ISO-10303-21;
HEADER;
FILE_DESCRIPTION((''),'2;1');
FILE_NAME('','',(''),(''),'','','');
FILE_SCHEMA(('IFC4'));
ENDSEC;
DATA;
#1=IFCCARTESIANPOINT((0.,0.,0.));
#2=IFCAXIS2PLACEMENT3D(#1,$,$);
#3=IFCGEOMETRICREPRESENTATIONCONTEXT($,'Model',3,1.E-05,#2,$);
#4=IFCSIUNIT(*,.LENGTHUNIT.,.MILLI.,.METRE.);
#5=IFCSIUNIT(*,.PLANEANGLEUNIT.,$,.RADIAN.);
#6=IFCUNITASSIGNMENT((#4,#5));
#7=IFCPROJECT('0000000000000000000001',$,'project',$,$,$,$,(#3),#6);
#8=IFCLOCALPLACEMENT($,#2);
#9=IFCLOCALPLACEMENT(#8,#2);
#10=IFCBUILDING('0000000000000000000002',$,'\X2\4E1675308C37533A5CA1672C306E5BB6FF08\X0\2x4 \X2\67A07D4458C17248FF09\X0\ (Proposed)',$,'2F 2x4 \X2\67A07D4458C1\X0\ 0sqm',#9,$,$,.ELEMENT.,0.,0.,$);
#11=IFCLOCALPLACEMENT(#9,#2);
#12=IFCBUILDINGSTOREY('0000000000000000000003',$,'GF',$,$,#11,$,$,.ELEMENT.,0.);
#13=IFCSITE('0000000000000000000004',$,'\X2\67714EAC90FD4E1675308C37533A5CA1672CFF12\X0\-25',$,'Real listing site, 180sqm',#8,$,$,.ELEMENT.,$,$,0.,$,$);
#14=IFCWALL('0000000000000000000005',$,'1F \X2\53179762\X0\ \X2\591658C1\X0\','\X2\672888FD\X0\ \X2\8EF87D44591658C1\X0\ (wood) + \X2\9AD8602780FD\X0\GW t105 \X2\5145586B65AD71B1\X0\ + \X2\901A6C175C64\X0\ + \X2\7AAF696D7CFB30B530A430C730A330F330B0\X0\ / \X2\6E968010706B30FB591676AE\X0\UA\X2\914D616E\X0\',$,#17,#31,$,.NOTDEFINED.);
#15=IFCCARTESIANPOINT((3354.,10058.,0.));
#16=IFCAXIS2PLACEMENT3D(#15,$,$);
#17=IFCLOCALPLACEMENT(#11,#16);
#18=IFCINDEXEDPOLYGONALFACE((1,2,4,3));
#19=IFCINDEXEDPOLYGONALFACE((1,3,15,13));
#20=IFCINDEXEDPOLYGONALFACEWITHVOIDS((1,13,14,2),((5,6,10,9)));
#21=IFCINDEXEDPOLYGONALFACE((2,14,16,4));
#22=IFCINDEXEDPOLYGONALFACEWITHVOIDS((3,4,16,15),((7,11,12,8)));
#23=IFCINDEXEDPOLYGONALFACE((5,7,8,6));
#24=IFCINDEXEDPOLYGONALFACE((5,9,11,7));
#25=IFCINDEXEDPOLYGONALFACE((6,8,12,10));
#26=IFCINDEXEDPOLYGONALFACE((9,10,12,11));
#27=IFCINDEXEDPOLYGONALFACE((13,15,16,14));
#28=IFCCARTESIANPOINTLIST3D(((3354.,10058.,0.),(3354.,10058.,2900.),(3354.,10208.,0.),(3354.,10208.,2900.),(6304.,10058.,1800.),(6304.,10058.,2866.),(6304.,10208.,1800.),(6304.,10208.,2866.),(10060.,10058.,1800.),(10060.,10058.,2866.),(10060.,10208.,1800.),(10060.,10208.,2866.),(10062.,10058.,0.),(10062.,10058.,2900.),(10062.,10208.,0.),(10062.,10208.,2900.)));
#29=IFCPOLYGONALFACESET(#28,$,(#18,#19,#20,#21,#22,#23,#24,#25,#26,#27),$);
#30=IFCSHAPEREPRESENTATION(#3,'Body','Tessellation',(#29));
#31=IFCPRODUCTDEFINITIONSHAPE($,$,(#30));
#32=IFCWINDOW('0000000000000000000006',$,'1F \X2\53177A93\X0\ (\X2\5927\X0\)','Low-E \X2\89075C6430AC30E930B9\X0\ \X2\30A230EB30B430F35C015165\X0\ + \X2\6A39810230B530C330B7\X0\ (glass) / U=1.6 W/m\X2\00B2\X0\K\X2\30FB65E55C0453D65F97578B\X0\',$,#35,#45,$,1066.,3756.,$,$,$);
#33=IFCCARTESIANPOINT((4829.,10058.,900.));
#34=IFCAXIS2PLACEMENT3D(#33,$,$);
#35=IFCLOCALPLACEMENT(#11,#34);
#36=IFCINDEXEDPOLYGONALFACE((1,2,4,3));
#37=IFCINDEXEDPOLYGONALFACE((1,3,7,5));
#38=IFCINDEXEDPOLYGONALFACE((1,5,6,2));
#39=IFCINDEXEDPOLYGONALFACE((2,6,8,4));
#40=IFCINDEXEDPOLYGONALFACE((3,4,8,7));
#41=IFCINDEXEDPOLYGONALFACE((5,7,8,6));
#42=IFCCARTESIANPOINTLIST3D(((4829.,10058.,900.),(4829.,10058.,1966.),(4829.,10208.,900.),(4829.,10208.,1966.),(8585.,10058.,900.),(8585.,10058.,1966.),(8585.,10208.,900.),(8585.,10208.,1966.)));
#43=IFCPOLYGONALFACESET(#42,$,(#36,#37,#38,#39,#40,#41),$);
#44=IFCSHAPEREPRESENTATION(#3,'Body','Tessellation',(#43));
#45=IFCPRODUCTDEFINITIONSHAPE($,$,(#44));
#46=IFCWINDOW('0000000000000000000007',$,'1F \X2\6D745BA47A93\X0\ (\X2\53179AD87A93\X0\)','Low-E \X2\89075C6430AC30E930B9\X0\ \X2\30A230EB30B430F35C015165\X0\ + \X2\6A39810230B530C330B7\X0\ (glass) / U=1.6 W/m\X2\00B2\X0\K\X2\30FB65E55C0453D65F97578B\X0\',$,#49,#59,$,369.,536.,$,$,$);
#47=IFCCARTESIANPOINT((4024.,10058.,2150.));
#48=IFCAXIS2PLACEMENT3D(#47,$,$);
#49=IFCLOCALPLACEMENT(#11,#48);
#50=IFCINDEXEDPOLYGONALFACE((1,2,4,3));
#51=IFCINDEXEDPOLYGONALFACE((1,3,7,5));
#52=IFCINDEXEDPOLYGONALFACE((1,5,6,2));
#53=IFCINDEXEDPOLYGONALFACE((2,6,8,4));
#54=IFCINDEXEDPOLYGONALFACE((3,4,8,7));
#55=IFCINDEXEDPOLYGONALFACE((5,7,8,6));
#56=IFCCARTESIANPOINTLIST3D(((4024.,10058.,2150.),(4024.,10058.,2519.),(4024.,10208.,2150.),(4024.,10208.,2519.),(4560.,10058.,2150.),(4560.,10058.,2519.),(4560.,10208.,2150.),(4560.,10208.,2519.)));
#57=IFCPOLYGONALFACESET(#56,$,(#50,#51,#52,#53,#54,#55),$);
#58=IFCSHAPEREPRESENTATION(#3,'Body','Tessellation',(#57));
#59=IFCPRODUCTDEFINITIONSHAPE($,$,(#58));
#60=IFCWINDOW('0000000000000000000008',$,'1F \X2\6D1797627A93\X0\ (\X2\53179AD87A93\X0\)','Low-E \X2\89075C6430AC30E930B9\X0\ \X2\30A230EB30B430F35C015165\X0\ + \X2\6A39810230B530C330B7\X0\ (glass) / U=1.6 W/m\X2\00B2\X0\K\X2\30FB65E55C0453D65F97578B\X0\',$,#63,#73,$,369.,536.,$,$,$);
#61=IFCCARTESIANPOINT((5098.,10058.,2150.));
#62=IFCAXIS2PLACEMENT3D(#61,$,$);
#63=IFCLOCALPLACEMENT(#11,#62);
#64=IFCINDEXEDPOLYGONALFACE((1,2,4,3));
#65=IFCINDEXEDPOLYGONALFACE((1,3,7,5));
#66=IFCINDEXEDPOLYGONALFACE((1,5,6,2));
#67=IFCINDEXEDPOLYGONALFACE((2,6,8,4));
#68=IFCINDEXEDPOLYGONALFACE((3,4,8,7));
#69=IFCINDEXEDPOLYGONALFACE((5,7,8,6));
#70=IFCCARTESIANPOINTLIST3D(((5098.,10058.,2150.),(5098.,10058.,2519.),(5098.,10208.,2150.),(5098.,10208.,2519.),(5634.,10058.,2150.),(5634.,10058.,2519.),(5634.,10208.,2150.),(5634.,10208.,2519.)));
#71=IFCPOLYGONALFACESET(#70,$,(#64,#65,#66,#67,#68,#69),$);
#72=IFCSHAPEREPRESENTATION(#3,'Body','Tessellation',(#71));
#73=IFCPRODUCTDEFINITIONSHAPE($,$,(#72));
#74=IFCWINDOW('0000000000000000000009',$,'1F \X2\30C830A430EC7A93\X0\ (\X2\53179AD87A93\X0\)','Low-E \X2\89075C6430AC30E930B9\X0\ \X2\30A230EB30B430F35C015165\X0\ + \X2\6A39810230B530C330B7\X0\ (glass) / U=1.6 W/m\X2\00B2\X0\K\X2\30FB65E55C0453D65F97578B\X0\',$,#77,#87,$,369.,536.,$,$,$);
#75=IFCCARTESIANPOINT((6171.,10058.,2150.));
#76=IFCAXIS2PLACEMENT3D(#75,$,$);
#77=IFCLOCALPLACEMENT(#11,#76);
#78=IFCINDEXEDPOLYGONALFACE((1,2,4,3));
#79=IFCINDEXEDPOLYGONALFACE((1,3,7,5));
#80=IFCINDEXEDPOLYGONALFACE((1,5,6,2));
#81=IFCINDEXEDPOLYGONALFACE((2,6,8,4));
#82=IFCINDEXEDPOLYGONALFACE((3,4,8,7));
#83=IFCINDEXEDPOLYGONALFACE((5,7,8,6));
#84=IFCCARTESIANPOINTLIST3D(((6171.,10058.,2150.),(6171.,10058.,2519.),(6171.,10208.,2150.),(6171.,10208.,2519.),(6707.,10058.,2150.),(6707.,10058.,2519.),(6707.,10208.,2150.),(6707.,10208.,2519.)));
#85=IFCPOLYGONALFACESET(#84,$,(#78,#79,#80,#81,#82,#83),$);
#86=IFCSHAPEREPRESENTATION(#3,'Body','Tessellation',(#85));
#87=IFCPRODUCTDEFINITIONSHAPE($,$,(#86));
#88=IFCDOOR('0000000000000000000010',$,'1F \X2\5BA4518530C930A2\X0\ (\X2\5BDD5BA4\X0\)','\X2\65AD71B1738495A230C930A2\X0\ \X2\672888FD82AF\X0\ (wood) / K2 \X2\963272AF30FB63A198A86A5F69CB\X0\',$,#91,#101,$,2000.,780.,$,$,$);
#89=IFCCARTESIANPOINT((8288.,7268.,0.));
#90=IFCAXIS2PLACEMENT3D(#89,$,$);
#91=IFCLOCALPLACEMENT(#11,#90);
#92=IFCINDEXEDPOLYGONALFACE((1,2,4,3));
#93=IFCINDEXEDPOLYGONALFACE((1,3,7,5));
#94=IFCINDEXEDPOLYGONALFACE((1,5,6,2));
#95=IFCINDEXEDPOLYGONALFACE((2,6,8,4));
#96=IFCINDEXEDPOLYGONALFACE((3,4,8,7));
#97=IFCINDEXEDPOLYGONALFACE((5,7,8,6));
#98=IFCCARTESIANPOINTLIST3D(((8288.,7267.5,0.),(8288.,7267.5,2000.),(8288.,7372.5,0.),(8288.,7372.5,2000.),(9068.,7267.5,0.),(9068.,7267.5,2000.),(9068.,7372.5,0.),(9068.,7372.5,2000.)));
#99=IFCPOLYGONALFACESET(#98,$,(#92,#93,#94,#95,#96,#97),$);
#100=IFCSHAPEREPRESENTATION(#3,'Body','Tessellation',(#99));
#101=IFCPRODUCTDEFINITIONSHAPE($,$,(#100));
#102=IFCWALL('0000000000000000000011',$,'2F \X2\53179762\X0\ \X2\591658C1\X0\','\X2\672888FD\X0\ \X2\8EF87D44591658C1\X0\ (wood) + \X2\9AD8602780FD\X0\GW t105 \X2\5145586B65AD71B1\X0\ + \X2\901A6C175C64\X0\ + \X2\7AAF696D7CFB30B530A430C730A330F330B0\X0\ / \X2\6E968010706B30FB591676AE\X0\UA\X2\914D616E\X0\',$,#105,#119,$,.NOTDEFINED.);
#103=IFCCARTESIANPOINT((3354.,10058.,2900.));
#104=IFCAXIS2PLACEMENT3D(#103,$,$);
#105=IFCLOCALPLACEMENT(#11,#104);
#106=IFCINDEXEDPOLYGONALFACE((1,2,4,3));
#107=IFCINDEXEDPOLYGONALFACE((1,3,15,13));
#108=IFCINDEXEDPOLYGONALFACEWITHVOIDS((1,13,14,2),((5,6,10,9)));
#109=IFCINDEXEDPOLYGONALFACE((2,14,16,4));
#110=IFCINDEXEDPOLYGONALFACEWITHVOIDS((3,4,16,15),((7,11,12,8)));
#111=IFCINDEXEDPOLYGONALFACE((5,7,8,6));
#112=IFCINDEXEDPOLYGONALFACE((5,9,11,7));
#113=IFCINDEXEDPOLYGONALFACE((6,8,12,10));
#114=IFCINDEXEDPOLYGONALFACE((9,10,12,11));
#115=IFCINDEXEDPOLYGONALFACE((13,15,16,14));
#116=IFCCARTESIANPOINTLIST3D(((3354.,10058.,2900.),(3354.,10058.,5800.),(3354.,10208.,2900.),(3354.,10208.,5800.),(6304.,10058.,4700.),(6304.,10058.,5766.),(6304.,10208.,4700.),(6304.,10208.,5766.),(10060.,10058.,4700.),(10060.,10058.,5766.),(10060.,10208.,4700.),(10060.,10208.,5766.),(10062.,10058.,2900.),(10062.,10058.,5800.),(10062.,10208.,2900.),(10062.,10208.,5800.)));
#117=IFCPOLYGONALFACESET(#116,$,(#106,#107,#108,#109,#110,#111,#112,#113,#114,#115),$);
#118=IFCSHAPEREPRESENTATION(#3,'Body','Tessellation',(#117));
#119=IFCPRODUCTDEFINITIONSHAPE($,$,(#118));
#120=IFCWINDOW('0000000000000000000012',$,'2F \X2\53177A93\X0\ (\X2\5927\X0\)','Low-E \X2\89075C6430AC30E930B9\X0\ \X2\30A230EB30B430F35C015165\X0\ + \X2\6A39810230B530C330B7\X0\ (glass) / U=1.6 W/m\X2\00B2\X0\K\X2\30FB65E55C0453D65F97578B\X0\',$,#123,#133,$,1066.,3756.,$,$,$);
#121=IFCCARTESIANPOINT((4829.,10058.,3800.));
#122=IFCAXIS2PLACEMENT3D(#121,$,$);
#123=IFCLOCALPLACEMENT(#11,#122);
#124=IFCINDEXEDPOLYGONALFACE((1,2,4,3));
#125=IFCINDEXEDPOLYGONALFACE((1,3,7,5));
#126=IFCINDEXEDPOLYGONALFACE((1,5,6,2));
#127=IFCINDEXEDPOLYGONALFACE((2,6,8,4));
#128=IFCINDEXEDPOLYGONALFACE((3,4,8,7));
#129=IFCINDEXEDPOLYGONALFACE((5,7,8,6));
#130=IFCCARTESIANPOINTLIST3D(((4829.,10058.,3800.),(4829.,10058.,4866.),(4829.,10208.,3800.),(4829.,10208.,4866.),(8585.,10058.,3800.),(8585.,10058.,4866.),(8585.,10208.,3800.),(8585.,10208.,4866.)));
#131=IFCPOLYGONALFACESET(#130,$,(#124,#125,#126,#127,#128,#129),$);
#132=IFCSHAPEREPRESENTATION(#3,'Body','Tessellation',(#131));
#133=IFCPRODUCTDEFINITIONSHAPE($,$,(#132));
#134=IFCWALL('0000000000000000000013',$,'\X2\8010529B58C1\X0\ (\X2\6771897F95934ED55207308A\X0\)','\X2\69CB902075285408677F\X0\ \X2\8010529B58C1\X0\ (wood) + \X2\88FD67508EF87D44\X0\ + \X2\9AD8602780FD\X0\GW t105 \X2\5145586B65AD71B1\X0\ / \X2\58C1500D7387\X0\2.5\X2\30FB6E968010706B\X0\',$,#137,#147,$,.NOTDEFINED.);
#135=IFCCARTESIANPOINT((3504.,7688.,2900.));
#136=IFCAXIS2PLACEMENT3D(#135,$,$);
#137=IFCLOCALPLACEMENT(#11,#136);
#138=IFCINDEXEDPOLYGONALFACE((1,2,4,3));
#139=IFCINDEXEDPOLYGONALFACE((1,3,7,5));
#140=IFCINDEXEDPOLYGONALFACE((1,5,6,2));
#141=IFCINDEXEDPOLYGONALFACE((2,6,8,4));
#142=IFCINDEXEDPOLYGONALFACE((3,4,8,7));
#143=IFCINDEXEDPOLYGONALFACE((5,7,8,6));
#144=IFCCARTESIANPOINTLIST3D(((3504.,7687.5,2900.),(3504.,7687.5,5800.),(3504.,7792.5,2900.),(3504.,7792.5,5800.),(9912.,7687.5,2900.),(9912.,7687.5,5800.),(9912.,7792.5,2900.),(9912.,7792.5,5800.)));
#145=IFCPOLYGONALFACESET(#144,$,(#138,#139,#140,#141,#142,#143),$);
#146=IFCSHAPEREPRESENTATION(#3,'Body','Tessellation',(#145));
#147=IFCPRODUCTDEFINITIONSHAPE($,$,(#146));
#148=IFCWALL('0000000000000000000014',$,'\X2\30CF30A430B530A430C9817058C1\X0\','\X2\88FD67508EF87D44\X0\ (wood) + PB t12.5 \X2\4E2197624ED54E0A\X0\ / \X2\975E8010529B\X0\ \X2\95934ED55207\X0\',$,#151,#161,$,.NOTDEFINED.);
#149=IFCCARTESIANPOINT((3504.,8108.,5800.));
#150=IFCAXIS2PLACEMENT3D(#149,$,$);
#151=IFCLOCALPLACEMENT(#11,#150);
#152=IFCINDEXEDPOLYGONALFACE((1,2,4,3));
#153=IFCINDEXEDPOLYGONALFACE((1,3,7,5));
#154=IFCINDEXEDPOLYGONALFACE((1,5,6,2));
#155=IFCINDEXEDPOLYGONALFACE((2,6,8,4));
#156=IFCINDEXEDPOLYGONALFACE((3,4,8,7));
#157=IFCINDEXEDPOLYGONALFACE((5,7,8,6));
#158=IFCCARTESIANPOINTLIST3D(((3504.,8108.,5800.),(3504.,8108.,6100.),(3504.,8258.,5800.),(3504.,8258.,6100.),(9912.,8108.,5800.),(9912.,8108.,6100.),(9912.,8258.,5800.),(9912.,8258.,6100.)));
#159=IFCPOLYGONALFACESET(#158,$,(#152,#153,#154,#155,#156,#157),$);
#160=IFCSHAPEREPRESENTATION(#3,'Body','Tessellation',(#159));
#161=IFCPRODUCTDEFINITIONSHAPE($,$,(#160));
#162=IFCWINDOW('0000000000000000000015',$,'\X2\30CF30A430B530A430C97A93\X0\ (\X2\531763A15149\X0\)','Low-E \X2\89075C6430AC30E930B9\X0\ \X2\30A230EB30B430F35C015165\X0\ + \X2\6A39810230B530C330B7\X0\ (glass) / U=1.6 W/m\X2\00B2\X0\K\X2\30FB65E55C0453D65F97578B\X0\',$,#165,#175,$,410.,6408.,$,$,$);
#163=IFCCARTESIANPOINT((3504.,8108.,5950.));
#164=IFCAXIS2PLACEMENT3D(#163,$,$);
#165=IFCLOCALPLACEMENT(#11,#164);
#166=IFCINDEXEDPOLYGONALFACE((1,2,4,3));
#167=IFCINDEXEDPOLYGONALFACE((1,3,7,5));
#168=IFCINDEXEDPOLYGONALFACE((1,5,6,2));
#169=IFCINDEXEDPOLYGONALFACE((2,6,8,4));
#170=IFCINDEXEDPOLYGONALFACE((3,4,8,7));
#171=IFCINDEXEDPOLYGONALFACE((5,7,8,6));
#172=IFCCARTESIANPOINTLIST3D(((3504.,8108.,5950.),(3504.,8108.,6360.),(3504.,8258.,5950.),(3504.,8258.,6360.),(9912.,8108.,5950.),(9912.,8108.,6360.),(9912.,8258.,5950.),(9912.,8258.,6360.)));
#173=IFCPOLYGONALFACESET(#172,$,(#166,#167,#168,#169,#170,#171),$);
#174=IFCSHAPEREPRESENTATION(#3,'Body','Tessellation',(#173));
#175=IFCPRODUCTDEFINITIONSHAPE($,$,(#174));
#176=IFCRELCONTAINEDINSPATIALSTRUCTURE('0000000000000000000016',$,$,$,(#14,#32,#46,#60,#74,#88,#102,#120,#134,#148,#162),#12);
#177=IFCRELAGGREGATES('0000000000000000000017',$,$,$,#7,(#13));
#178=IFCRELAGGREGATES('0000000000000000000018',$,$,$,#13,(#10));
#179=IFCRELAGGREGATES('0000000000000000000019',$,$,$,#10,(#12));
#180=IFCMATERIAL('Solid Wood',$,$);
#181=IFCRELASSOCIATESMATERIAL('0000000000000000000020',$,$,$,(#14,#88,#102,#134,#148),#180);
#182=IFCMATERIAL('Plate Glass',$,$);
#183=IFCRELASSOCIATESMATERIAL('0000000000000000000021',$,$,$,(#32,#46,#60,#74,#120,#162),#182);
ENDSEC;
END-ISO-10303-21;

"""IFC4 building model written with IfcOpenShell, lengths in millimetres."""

from ifc_helpers import new_model, si_unit, frame, frame_2d, origin, place, context, project, spatial, rectangle, extrude, material, element, fill, save


model = new_model("IFC4")

# Units and contexts
model_context = context("Model", 3, precision=1e-05, world=origin())
ifc_project = project(units=[si_unit("LENGTHUNIT", "METRE", prefix="MILLI"), si_unit("PLANEANGLEUNIT", "RADIAN")], contexts=[model_context])

# Site, building, storey
site_placement = place(None, origin())
site = spatial("IfcSite", under=ifc_project, at=site_placement, Name="東京都世田谷区岡本２-25", ObjectType="Real listing site, 180sqm", CompositionType="ELEMENT", RefElevation=0.0)
building_placement = place(site_placement, origin())
building = spatial("IfcBuilding", under=site, at=building_placement, Name="世田谷区岡本の家（2x4 枠組壁版） (Proposed)", ObjectType="2F 2x4 枠組壁 0sqm", CompositionType="ELEMENT", ElevationOfRefHeight=0.0, ElevationOfTerrain=0.0)
storey_placement = place(building_placement, origin())
storey = spatial("IfcBuildingStorey", under=building, at=storey_placement, Name="GF", CompositionType="ELEMENT", Elevation=0.0)

# Wall, openings, windows
ifc_material_1 = material(Name="Solid Wood")
wall_1_placement = place(storey_placement, frame((3354.0, 10058.0, 0.0)))
wall_1 = element("IfcWall", 1, at=wall_1_placement, inside=storey, material=ifc_material_1, Name="1F 北面 外壁", Description="木製 軸組外壁 (wood) + 高性能GW t105 充填断熱 + 通気層 + 窯業系サイディング / 準耐火・外皮UA配慮", PredefinedType="NOTDEFINED", context=model_context, shape_type="SweptSolid", body=[
    extrude(rectangle(XDim=6708.0, YDim=150.0, at=frame_2d((3354.0, 75.0))), frame((3354.0, 10058.0, 0.0)), (0.0, 0.0, 1.0), 2900.0),
])
opening_1_placement = place(storey_placement, frame((4829.0, 10058.0, 900.0)))
opening_1 = element("IfcOpeningElement", 2, at=opening_1_placement, cuts=wall_1, PredefinedType="NOTDEFINED", context=model_context, shape_type="SweptSolid", body=[
    extrude(rectangle(XDim=3756.0, YDim=150.0, at=frame_2d((1878.0, 75.0))), frame((4829.0, 10058.0, 900.0)), (0.0, 0.0, 1.0), 1066.0),
])
opening_2_placement = place(storey_placement, frame((4024.0, 10058.0, 2150.0)))
opening_2 = element("IfcOpeningElement", 3, at=opening_2_placement, cuts=wall_1, PredefinedType="NOTDEFINED", context=model_context, shape_type="SweptSolid", body=[
    extrude(rectangle(XDim=536.0, YDim=150.0, at=frame_2d((268.0, 75.0))), frame((4024.0, 10058.0, 2150.0)), (0.0, 0.0, 1.0), 369.0),
])
opening_3_placement = place(storey_placement, frame((5098.0, 10058.0, 2150.0)))
opening_3 = element("IfcOpeningElement", 4, at=opening_3_placement, cuts=wall_1, PredefinedType="NOTDEFINED", context=model_context, shape_type="SweptSolid", body=[
    extrude(rectangle(XDim=536.0, YDim=150.0, at=frame_2d((268.0, 75.0))), frame((5098.0, 10058.0, 2150.0)), (0.0, 0.0, 1.0), 369.0),
])
opening_4_placement = place(storey_placement, frame((6171.0, 10058.0, 2150.0)))
opening_4 = element("IfcOpeningElement", 5, at=opening_4_placement, cuts=wall_1, PredefinedType="NOTDEFINED", context=model_context, shape_type="SweptSolid", body=[
    extrude(rectangle(XDim=536.0, YDim=150.0, at=frame_2d((268.0, 75.0))), frame((6171.0, 10058.0, 2150.0)), (0.0, 0.0, 1.0), 369.0),
])
ifc_material_2 = material(Name="Plate Glass")
window_1_placement = place(storey_placement, frame((4829.0, 10058.0, 900.0)))
window_1 = element("IfcWindow", 6, at=window_1_placement, inside=storey, material=ifc_material_2, Name="1F 北窓 (大)", Description="Low-E 複層ガラス アルゴン封入 + 樹脂サッシ (glass) / U=1.6 W/m²K・日射取得型", OverallHeight=1066.0, OverallWidth=3756.0, context=model_context, shape_type="SweptSolid", body=[
    extrude(rectangle(XDim=3756.0, YDim=150.0, at=frame_2d((1878.0, 75.0))), frame((4829.0, 10058.0, 900.0)), (0.0, 0.0, 1.0), 1066.0),
])
fill(opening_1, window_1)
window_2_placement = place(storey_placement, frame((4024.0, 10058.0, 2150.0)))
window_2 = element("IfcWindow", 7, at=window_2_placement, inside=storey, material=ifc_material_2, Name="1F 浴室窓 (北高窓)", Description="Low-E 複層ガラス アルゴン封入 + 樹脂サッシ (glass) / U=1.6 W/m²K・日射取得型", OverallHeight=369.0, OverallWidth=536.0, context=model_context, shape_type="SweptSolid", body=[
    extrude(rectangle(XDim=536.0, YDim=150.0, at=frame_2d((268.0, 75.0))), frame((4024.0, 10058.0, 2150.0)), (0.0, 0.0, 1.0), 369.0),
])
fill(opening_2, window_2)
window_3_placement = place(storey_placement, frame((5098.0, 10058.0, 2150.0)))
window_3 = element("IfcWindow", 8, at=window_3_placement, inside=storey, material=ifc_material_2, Name="1F 洗面窓 (北高窓)", Description="Low-E 複層ガラス アルゴン封入 + 樹脂サッシ (glass) / U=1.6 W/m²K・日射取得型", OverallHeight=369.0, OverallWidth=536.0, context=model_context, shape_type="SweptSolid", body=[
    extrude(rectangle(XDim=536.0, YDim=150.0, at=frame_2d((268.0, 75.0))), frame((5098.0, 10058.0, 2150.0)), (0.0, 0.0, 1.0), 369.0),
])
fill(opening_3, window_3)
window_4_placement = place(storey_placement, frame((6171.0, 10058.0, 2150.0)))
window_4 = element("IfcWindow", 9, at=window_4_placement, inside=storey, material=ifc_material_2, Name="1F トイレ窓 (北高窓)", Description="Low-E 複層ガラス アルゴン封入 + 樹脂サッシ (glass) / U=1.6 W/m²K・日射取得型", OverallHeight=369.0, OverallWidth=536.0, context=model_context, shape_type="SweptSolid", body=[
    extrude(rectangle(XDim=536.0, YDim=150.0, at=frame_2d((268.0, 75.0))), frame((6171.0, 10058.0, 2150.0)), (0.0, 0.0, 1.0), 369.0),
])
fill(opening_4, window_4)

# Door
door_1_placement = place(storey_placement, frame((8288.0, 7268.0, 0.0)))
element("IfcDoor", 10, at=door_1_placement, inside=storey, material=ifc_material_1, Name="1F 室内ドア (寝室)", Description="断熱玄関ドア 木製芯 (wood) / K2 防犯・採風機構", OverallHeight=2000.0, OverallWidth=780.0, context=model_context, shape_type="SweptSolid", body=[
    extrude(rectangle(XDim=780.0, YDim=105.0, at=frame_2d((390.0, 52.0))), frame((8288.0, 7268.0, 0.0)), (0.0, 0.0, 1.0), 2000.0),
])

# Wall, opening, window
wall_2_placement = place(storey_placement, frame((3354.0, 10058.0, 2900.0)))
wall_2 = element("IfcWall", 11, at=wall_2_placement, inside=storey, material=ifc_material_1, Name="2F 北面 外壁", Description="木製 軸組外壁 (wood) + 高性能GW t105 充填断熱 + 通気層 + 窯業系サイディング / 準耐火・外皮UA配慮", PredefinedType="NOTDEFINED", context=model_context, shape_type="SweptSolid", body=[
    extrude(rectangle(XDim=6708.0, YDim=150.0, at=frame_2d((3354.0, 75.0))), frame((3354.0, 10058.0, 2900.0)), (0.0, 0.0, 1.0), 2900.0),
])
opening_5_placement = place(storey_placement, frame((4829.0, 10058.0, 3800.0)))
opening_5 = element("IfcOpeningElement", 12, at=opening_5_placement, cuts=wall_2, PredefinedType="NOTDEFINED", context=model_context, shape_type="SweptSolid", body=[
    extrude(rectangle(XDim=3756.0, YDim=150.0, at=frame_2d((1878.0, 75.0))), frame((4829.0, 10058.0, 3800.0)), (0.0, 0.0, 1.0), 1066.0),
])
window_5_placement = place(storey_placement, frame((4829.0, 10058.0, 3800.0)))
window_5 = element("IfcWindow", 13, at=window_5_placement, inside=storey, material=ifc_material_2, Name="2F 北窓 (大)", Description="Low-E 複層ガラス アルゴン封入 + 樹脂サッシ (glass) / U=1.6 W/m²K・日射取得型", OverallHeight=1066.0, OverallWidth=3756.0, context=model_context, shape_type="SweptSolid", body=[
    extrude(rectangle(XDim=3756.0, YDim=150.0, at=frame_2d((1878.0, 75.0))), frame((4829.0, 10058.0, 3800.0)), (0.0, 0.0, 1.0), 1066.0),
])
fill(opening_5, window_5)

# Wall
wall_3_placement = place(storey_placement, frame((3504.0, 7688.0, 2900.0)))
element("IfcWall", 14, at=wall_3_placement, inside=storey, material=ifc_material_1, Name="耐力壁 (東西間仕切り)", Description="構造用合板 耐力壁 (wood) + 製材軸組 + 高性能GW t105 充填断熱 / 壁倍率2.5・準耐火", PredefinedType="NOTDEFINED", context=model_context, shape_type="SweptSolid", body=[
    extrude(rectangle(XDim=6408.0, YDim=105.0, at=frame_2d((3204.0, 52.0))), frame((3504.0, 7688.0, 2900.0)), (0.0, 0.0, 1.0), 2900.0),
])

# Wall, opening, window
wall_4_placement = place(storey_placement, frame((3504.0, 8108.0, 5800.0)))
wall_4 = element("IfcWall", 15, at=wall_4_placement, inside=storey, material=ifc_material_1, Name="ハイサイド腰壁", Description="製材軸組 (wood) + PB t12.5 両面仕上 / 非耐力 間仕切", PredefinedType="NOTDEFINED", context=model_context, shape_type="SweptSolid", body=[
    extrude(rectangle(XDim=6408.0, YDim=150.0, at=frame_2d((3204.0, 75.0))), frame((3504.0, 8108.0, 5800.0)), (0.0, 0.0, 1.0), 700.0),
])
opening_6_placement = place(storey_placement, frame((3504.0, 8108.0, 5950.0)))
opening_6 = element("IfcOpeningElement", 16, at=opening_6_placement, cuts=wall_4, PredefinedType="NOTDEFINED", context=model_context, shape_type="SweptSolid", body=[
    extrude(rectangle(XDim=6408.0, YDim=150.0, at=frame_2d((3204.0, 75.0))), frame((3504.0, 8108.0, 5950.0)), (0.0, 0.0, 1.0), 410.0),
])
window_6_placement = place(storey_placement, frame((3504.0, 8108.0, 5950.0)))
window_6 = element("IfcWindow", 17, at=window_6_placement, inside=storey, material=ifc_material_2, Name="ハイサイド窓 (北採光)", Description="Low-E 複層ガラス アルゴン封入 + 樹脂サッシ (glass) / U=1.6 W/m²K・日射取得型", OverallHeight=410.0, OverallWidth=6408.0, context=model_context, shape_type="SweptSolid", body=[
    extrude(rectangle(XDim=6408.0, YDim=150.0, at=frame_2d((3204.0, 75.0))), frame((3504.0, 8108.0, 5950.0)), (0.0, 0.0, 1.0), 410.0),
])
fill(opening_6, window_6)

save(model, "model.ifc")
